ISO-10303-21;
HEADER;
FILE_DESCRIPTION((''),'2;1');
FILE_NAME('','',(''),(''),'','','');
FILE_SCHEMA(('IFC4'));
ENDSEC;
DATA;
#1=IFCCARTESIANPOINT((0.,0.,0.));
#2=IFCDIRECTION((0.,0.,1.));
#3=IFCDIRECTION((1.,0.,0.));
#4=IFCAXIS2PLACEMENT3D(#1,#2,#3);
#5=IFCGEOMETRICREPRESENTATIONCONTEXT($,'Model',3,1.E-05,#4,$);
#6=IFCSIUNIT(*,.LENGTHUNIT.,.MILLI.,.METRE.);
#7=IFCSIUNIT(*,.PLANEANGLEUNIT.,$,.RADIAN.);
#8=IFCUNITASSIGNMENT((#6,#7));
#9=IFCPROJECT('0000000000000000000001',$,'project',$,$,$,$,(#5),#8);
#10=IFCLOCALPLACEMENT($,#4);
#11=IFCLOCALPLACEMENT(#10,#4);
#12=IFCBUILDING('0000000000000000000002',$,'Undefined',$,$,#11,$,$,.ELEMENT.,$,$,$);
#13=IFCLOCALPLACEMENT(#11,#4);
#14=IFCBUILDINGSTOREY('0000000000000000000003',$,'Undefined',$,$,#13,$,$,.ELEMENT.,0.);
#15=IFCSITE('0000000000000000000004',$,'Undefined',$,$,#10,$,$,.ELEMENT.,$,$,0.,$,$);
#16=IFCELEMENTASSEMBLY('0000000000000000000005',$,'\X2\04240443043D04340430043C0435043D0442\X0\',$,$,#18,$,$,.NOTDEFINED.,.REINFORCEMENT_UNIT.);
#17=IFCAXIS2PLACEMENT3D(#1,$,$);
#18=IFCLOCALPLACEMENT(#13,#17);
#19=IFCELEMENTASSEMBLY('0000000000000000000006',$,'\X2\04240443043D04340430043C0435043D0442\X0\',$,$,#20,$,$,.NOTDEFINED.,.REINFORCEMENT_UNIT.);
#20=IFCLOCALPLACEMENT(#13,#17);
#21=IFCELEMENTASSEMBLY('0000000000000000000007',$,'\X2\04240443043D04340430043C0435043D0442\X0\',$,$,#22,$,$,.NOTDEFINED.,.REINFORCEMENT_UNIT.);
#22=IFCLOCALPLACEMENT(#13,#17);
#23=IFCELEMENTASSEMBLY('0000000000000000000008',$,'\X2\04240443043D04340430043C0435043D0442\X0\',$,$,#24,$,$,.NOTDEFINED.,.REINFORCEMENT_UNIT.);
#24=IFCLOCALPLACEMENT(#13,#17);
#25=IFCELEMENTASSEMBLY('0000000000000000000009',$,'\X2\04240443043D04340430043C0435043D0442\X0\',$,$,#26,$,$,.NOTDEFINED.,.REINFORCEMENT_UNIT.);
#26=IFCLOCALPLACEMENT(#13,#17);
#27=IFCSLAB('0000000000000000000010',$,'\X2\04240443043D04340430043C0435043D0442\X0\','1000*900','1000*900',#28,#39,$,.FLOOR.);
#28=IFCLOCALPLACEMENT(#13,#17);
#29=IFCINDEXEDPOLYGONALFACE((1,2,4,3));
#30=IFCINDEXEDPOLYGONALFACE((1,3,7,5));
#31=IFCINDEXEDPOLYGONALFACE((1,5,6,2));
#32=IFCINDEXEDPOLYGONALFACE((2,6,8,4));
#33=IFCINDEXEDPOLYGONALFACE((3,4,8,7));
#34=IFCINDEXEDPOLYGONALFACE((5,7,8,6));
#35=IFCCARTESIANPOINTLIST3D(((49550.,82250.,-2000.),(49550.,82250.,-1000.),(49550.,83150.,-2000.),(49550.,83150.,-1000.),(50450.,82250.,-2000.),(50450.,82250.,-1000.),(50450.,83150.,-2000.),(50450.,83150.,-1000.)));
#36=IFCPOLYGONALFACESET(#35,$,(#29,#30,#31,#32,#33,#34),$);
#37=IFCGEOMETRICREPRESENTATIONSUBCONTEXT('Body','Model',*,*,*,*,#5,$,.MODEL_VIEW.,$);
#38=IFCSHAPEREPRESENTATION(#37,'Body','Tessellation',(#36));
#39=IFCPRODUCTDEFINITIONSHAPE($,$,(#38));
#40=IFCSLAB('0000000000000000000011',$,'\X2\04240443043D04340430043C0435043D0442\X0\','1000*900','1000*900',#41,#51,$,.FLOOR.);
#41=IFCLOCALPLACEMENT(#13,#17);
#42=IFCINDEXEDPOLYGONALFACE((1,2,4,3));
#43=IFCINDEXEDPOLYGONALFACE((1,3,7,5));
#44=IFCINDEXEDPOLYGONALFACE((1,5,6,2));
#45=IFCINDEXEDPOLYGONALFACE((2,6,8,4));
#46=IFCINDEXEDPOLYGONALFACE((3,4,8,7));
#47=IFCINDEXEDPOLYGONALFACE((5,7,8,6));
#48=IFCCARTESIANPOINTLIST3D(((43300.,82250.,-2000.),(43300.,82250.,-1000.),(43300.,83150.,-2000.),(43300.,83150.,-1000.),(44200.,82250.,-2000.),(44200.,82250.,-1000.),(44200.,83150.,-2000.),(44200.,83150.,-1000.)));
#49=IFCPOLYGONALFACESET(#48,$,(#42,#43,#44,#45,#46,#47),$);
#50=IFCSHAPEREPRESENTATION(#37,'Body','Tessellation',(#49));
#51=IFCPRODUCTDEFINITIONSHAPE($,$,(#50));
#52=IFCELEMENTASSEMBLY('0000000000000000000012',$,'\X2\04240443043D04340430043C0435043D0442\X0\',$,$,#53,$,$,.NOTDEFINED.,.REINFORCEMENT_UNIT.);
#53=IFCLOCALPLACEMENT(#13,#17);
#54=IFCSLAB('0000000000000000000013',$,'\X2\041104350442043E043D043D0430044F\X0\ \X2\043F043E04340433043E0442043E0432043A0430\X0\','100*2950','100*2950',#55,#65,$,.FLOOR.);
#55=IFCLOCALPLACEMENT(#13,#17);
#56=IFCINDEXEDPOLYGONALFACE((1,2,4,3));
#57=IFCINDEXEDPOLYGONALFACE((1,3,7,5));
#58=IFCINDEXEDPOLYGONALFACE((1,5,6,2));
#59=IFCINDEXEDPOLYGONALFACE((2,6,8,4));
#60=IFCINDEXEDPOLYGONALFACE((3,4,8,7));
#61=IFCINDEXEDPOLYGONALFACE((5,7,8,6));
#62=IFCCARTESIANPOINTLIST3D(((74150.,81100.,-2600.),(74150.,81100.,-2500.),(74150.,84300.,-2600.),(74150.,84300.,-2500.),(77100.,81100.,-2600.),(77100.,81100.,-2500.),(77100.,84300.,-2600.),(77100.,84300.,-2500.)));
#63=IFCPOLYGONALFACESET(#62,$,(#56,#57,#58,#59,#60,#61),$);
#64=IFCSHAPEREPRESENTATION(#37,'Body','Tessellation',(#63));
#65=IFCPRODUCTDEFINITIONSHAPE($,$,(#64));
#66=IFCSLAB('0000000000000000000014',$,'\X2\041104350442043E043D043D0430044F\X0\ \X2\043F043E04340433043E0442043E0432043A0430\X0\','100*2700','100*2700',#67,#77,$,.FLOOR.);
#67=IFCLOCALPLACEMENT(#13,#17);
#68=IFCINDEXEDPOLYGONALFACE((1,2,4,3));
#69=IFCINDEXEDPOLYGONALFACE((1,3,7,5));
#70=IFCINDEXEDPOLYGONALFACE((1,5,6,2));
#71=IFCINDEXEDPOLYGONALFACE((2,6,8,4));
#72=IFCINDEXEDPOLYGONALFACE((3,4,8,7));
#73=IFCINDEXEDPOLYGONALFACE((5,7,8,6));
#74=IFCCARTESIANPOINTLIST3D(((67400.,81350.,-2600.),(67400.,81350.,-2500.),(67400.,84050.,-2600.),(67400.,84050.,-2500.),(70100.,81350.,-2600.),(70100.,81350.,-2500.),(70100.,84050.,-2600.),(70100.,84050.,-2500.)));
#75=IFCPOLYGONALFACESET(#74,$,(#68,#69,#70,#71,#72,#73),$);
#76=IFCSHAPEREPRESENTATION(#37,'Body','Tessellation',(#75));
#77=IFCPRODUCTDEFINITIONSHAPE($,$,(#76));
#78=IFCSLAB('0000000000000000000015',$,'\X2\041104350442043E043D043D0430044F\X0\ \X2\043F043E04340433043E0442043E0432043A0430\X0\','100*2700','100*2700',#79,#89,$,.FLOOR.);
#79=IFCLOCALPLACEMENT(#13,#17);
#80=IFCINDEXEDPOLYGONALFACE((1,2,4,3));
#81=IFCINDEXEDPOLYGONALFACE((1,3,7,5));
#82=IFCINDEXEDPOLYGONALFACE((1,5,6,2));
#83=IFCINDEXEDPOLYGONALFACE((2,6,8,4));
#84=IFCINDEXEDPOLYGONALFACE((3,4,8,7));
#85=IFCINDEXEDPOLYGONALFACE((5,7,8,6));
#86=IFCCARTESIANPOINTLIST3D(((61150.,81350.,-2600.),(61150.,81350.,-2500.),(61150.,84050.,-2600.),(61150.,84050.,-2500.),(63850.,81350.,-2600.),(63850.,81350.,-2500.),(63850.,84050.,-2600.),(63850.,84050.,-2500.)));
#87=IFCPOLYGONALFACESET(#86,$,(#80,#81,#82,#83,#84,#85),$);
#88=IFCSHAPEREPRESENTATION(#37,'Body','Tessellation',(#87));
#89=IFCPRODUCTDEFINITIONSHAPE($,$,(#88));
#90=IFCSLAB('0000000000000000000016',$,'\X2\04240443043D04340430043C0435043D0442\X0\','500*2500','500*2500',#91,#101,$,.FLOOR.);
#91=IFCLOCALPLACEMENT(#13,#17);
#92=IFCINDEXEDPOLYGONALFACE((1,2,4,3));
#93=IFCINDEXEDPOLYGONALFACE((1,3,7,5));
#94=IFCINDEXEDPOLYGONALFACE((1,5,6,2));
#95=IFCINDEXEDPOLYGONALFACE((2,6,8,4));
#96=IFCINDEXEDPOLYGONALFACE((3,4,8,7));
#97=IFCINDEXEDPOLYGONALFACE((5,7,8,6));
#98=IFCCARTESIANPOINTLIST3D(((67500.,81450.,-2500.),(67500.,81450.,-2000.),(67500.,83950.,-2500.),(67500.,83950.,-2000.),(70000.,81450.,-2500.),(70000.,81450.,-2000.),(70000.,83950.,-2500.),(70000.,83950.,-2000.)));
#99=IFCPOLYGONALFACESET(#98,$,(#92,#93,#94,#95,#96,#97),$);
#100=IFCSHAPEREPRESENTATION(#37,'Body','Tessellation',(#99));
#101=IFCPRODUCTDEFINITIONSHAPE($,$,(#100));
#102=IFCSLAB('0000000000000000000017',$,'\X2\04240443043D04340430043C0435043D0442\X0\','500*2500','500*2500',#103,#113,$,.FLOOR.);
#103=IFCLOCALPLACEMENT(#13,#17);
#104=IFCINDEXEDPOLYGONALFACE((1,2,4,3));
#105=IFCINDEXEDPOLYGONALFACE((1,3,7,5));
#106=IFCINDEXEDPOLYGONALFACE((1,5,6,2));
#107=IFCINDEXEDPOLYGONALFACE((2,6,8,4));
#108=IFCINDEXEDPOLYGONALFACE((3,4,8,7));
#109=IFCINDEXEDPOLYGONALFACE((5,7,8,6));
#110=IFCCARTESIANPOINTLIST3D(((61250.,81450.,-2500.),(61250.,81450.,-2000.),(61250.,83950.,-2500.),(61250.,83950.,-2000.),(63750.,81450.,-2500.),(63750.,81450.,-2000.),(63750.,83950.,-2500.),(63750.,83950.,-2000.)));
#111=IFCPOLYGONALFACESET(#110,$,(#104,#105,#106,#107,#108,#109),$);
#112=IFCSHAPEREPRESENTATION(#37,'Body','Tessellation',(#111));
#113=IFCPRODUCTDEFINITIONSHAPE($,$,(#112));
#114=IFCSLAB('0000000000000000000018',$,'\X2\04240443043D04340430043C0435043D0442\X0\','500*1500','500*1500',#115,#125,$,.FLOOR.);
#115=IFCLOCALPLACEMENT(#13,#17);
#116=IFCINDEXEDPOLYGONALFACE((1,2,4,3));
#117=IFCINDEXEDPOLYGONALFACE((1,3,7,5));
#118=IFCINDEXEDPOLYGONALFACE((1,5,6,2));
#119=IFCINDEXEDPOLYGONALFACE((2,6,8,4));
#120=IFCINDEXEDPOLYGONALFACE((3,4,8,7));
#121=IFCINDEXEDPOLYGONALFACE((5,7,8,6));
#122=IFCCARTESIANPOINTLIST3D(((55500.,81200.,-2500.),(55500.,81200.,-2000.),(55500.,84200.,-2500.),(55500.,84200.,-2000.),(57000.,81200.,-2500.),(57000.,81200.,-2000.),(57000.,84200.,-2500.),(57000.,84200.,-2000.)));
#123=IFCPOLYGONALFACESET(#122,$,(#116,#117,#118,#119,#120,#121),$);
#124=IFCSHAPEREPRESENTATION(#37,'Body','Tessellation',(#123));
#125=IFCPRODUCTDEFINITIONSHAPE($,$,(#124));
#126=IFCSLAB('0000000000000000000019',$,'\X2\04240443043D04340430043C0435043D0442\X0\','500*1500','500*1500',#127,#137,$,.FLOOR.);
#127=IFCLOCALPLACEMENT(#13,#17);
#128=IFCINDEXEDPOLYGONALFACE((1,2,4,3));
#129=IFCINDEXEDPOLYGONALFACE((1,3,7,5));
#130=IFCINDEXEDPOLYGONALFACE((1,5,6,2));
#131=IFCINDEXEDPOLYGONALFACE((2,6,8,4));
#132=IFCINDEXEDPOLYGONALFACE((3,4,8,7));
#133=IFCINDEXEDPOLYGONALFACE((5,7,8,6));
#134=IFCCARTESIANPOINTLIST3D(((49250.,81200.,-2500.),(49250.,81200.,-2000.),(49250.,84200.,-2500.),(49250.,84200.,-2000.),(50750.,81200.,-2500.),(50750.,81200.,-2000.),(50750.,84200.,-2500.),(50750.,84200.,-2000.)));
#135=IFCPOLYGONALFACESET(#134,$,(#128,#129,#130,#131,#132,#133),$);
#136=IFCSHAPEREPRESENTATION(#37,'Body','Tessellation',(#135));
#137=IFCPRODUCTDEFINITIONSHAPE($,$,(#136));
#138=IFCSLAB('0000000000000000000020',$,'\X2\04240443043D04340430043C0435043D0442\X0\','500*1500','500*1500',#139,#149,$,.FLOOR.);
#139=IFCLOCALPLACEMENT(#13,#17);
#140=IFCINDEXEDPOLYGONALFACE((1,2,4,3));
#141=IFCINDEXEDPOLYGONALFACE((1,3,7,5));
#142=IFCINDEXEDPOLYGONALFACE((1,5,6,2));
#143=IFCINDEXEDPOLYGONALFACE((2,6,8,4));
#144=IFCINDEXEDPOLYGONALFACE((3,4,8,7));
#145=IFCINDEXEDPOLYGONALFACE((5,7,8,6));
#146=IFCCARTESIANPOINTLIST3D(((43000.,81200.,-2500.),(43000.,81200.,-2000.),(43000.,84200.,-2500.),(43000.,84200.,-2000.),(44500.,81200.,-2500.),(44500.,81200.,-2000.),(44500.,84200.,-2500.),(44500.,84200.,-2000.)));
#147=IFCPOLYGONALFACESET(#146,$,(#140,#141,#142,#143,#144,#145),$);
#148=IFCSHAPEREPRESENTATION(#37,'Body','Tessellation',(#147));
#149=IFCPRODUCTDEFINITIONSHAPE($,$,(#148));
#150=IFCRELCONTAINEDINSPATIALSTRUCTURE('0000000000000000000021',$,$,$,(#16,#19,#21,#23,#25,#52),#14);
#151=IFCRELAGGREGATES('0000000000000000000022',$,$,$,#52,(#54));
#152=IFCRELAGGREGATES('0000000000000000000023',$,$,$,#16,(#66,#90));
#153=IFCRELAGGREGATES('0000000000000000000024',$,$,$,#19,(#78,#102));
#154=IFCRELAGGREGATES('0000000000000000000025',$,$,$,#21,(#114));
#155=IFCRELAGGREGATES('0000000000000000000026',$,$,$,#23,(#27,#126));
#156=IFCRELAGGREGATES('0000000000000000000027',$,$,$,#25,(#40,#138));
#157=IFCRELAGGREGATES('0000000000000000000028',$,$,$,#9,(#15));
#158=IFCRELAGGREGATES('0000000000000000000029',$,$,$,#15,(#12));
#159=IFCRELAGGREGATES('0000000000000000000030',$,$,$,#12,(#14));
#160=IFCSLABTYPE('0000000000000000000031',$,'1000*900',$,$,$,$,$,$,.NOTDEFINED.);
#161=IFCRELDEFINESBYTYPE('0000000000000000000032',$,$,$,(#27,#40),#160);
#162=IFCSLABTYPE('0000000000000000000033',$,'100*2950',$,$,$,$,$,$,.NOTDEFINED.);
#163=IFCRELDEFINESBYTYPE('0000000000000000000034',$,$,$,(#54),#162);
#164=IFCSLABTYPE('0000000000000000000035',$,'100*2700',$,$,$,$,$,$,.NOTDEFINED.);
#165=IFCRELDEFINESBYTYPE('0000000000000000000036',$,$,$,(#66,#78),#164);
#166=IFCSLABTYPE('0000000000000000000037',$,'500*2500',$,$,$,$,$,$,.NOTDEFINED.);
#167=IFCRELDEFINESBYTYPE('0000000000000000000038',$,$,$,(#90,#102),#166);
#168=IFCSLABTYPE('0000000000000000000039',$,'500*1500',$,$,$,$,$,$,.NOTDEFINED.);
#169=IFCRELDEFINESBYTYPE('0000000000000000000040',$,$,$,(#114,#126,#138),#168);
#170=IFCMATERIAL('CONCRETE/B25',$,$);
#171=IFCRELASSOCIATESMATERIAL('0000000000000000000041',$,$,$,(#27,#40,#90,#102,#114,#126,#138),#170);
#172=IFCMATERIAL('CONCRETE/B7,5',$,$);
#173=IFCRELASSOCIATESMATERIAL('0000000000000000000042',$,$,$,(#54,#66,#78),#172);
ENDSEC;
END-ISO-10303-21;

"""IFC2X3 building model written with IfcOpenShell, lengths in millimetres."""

from ifc_helpers import new_model, si_unit, frame, origin_with_axes, place, context, subcontext, project, spatial, polyline, outline, extrude, material, type_object, element, aggregate, save


model = new_model("IFC2X3")

# Units and contexts
model_context = context("Model", 3, precision=1e-05, world=origin_with_axes())
body_context = subcontext(model_context, "Body", "Model", "MODEL_VIEW")
ifc_project = project(units=[si_unit("LENGTHUNIT", "METRE", prefix="MILLI"), si_unit("PLANEANGLEUNIT", "RADIAN")], contexts=[model_context])

# Site, building, storey
site_placement = place(None, origin_with_axes())
site = spatial("IfcSite", under=ifc_project, at=site_placement, Name="Undefined", CompositionType="ELEMENT", RefElevation=0.0)
building_placement = place(site_placement, origin_with_axes())
building = spatial("IfcBuilding", under=site, at=building_placement, Name="Undefined", CompositionType="ELEMENT")
storey_placement = place(building_placement, origin_with_axes())
storey = spatial("IfcBuildingStorey", under=building, at=storey_placement, Name="Undefined", CompositionType="ELEMENT", Elevation=0.0)

# Element assemblies
assembly_1_placement = place(storey_placement, origin_with_axes())
assembly_1 = element("IfcElementAssembly", 1, at=assembly_1_placement, inside=storey, Name="Фундамент", AssemblyPlace="NOTDEFINED", PredefinedType="REINFORCEMENT_UNIT")
ifc_material_1 = material(Name="CONCRETE/B25")
assembly_2_placement = place(storey_placement, origin_with_axes())
assembly_2 = element("IfcElementAssembly", 2, at=assembly_2_placement, inside=storey, Name="Фундамент", AssemblyPlace="NOTDEFINED", PredefinedType="REINFORCEMENT_UNIT")
assembly_3_placement = place(storey_placement, origin_with_axes())
assembly_3 = element("IfcElementAssembly", 3, at=assembly_3_placement, inside=storey, Name="Фундамент", AssemblyPlace="NOTDEFINED", PredefinedType="REINFORCEMENT_UNIT")
assembly_4_placement = place(storey_placement, origin_with_axes())
assembly_4 = element("IfcElementAssembly", 4, at=assembly_4_placement, inside=storey, Name="Фундамент", AssemblyPlace="NOTDEFINED", PredefinedType="REINFORCEMENT_UNIT")
assembly_5_placement = place(storey_placement, origin_with_axes())
assembly_5 = element("IfcElementAssembly", 5, at=assembly_5_placement, inside=storey, Name="Фундамент", AssemblyPlace="NOTDEFINED", PredefinedType="REINFORCEMENT_UNIT")

# Slabs
ifc_material_2 = material(Name="CONCRETE/B7,5")
slab_type_1 = type_object("IfcSlabType", Name="1000*900", PredefinedType="NOTDEFINED")
slab_1_placement = place(assembly_4_placement, frame((49550.0, 83150.0, -1500.0), z_axis=(0.0, 0.0, 1.0), x_axis=(0.0, -1.0, 0.0)))
slab_1 = element("IfcSlab", 6, at=slab_1_placement, type_object=slab_type_1, material=ifc_material_1, Name="Фундамент", Description="1000*900", ObjectType="1000*900", PredefinedType="FLOOR", context=body_context, shape_type="SweptSolid", body=[
    extrude(outline(polyline([(0.0, 0.0), (900.0, 0.0), (900.0, 900.0), (0.0, 900.0), (0.0, 0.0)])), frame((0.0, 0.0, -500.0), z_axis=(0.0, 0.0, 1.0), x_axis=(1.0, 0.0, 0.0)), (0.0, 0.0, 1.0), 1000.0),
])
slab_2_placement = place(assembly_5_placement, frame((43300.0, 83150.0, -1500.0), z_axis=(0.0, 0.0, 1.0), x_axis=(0.0, -1.0, 0.0)))
slab_2 = element("IfcSlab", 7, at=slab_2_placement, type_object=slab_type_1, material=ifc_material_1, Name="Фундамент", Description="1000*900", ObjectType="1000*900", PredefinedType="FLOOR", context=body_context, shape_type="SweptSolid", body=[
    extrude(outline(polyline([(0.0, 0.0), (900.0, 0.0), (900.0, 900.0), (0.0, 900.0), (0.0, 0.0)])), frame((0.0, 0.0, -500.0), z_axis=(0.0, 0.0, 1.0), x_axis=(1.0, 0.0, 0.0)), (0.0, 0.0, 1.0), 1000.0),
])

# Element assembly, slab
assembly_6_placement = place(storey_placement, origin_with_axes())
assembly_6 = element("IfcElementAssembly", 8, at=assembly_6_placement, inside=storey, Name="Фундамент", AssemblyPlace="NOTDEFINED", PredefinedType="REINFORCEMENT_UNIT")
slab_type_2 = type_object("IfcSlabType", Name="100*2950", PredefinedType="NOTDEFINED")
slab_3_placement = place(assembly_6_placement, frame((74150.0, 84300.0, -2550.0), z_axis=(0.0, 0.0, 1.0), x_axis=(0.0, -1.0, 0.0)))
slab_3 = element("IfcSlab", 9, at=slab_3_placement, type_object=slab_type_2, material=ifc_material_2, Name="Бетонная подготовка", Description="100*2950", ObjectType="100*2950", PredefinedType="FLOOR", context=body_context, shape_type="SweptSolid", body=[
    extrude(outline(polyline([(0.0, 0.0), (3200.0, 0.0), (3200.0, 2950.0), (0.0, 2950.0), (0.0, 0.0)])), frame((0.0, 0.0, -50.0), z_axis=(0.0, 0.0, 1.0), x_axis=(1.0, 0.0, 0.0)), (0.0, 0.0, 1.0), 100.0),
])
aggregate(assembly_6, [slab_3])

# Slabs
slab_type_3 = type_object("IfcSlabType", Name="100*2700", PredefinedType="NOTDEFINED")
slab_4_placement = place(assembly_1_placement, frame((67400.0, 84050.0, -2550.0), z_axis=(0.0, 0.0, 1.0), x_axis=(0.0, -1.0, 0.0)))
slab_4 = element("IfcSlab", 10, at=slab_4_placement, type_object=slab_type_3, material=ifc_material_2, Name="Бетонная подготовка", Description="100*2700", ObjectType="100*2700", PredefinedType="FLOOR", context=body_context, shape_type="SweptSolid", body=[
    extrude(outline(polyline([(0.0, 0.0), (2700.0, 0.0), (2700.0, 2700.0), (0.0, 2700.0), (0.0, 0.0)])), frame((0.0, 0.0, -50.0), z_axis=(0.0, 0.0, 1.0), x_axis=(1.0, 0.0, 0.0)), (0.0, 0.0, 1.0), 100.0),
])
slab_5_placement = place(assembly_2_placement, frame((61150.0, 84050.0, -2550.0), z_axis=(0.0, 0.0, 1.0), x_axis=(0.0, -1.0, 0.0)))
slab_5 = element("IfcSlab", 11, at=slab_5_placement, type_object=slab_type_3, material=ifc_material_2, Name="Бетонная подготовка", Description="100*2700", ObjectType="100*2700", PredefinedType="FLOOR", context=body_context, shape_type="SweptSolid", body=[
    extrude(outline(polyline([(0.0, 0.0), (2700.0, 0.0), (2700.0, 2700.0), (0.0, 2700.0), (0.0, 0.0)])), frame((0.0, 0.0, -50.0), z_axis=(0.0, 0.0, 1.0), x_axis=(1.0, 0.0, 0.0)), (0.0, 0.0, 1.0), 100.0),
])
slab_type_4 = type_object("IfcSlabType", Name="500*2500", PredefinedType="NOTDEFINED")
slab_6_placement = place(assembly_1_placement, frame((67500.0, 83950.0, -2250.0), z_axis=(0.0, 0.0, 1.0), x_axis=(0.0, -1.0, 0.0)))
slab_6 = element("IfcSlab", 12, at=slab_6_placement, type_object=slab_type_4, material=ifc_material_1, Name="Фундамент", Description="500*2500", ObjectType="500*2500", PredefinedType="FLOOR", context=body_context, shape_type="SweptSolid", body=[
    extrude(outline(polyline([(0.0, 0.0), (2500.0, 0.0), (2500.0, 2500.0), (0.0, 2500.0), (0.0, 0.0)])), frame((0.0, 0.0, -250.0), z_axis=(0.0, 0.0, 1.0), x_axis=(1.0, 0.0, 0.0)), (0.0, 0.0, 1.0), 500.0),
])
aggregate(assembly_1, [slab_4, slab_6])
slab_7_placement = place(assembly_2_placement, frame((61250.0, 83950.0, -2250.0), z_axis=(0.0, 0.0, 1.0), x_axis=(0.0, -1.0, 0.0)))
slab_7 = element("IfcSlab", 13, at=slab_7_placement, type_object=slab_type_4, material=ifc_material_1, Name="Фундамент", Description="500*2500", ObjectType="500*2500", PredefinedType="FLOOR", context=body_context, shape_type="SweptSolid", body=[
    extrude(outline(polyline([(0.0, 0.0), (2500.0, 0.0), (2500.0, 2500.0), (0.0, 2500.0), (0.0, 0.0)])), frame((0.0, 0.0, -250.0), z_axis=(0.0, 0.0, 1.0), x_axis=(1.0, 0.0, 0.0)), (0.0, 0.0, 1.0), 500.0),
])
aggregate(assembly_2, [slab_5, slab_7])
slab_type_5 = type_object("IfcSlabType", Name="500*1500", PredefinedType="NOTDEFINED")
slab_8_placement = place(assembly_3_placement, frame((55500.0, 84200.0, -2250.0), z_axis=(0.0, 0.0, 1.0), x_axis=(0.0, -1.0, 0.0)))
slab_8 = element("IfcSlab", 14, at=slab_8_placement, type_object=slab_type_5, material=ifc_material_1, Name="Фундамент", Description="500*1500", ObjectType="500*1500", PredefinedType="FLOOR", context=body_context, shape_type="SweptSolid", body=[
    extrude(outline(polyline([(0.0, 0.0), (3000.0, 0.0), (3000.0, 1500.0), (0.0, 1500.0), (0.0, 0.0)])), frame((0.0, 0.0, -250.0), z_axis=(0.0, 0.0, 1.0), x_axis=(1.0, 0.0, 0.0)), (0.0, 0.0, 1.0), 500.0),
])
aggregate(assembly_3, [slab_8])
slab_9_placement = place(assembly_4_placement, frame((49250.0, 84200.0, -2250.0), z_axis=(0.0, 0.0, 1.0), x_axis=(0.0, -1.0, 0.0)))
slab_9 = element("IfcSlab", 15, at=slab_9_placement, type_object=slab_type_5, material=ifc_material_1, Name="Фундамент", Description="500*1500", ObjectType="500*1500", PredefinedType="FLOOR", context=body_context, shape_type="SweptSolid", body=[
    extrude(outline(polyline([(0.0, 0.0), (3000.0, 0.0), (3000.0, 1500.0), (0.0, 1500.0), (0.0, 0.0)])), frame((0.0, 0.0, -250.0), z_axis=(0.0, 0.0, 1.0), x_axis=(1.0, 0.0, 0.0)), (0.0, 0.0, 1.0), 500.0),
])
aggregate(assembly_4, [slab_1, slab_9])
slab_10_placement = place(assembly_5_placement, frame((43000.0, 84200.0, -2250.0), z_axis=(0.0, 0.0, 1.0), x_axis=(0.0, -1.0, 0.0)))
slab_10 = element("IfcSlab", 16, at=slab_10_placement, type_object=slab_type_5, material=ifc_material_1, Name="Фундамент", Description="500*1500", ObjectType="500*1500", PredefinedType="FLOOR", context=body_context, shape_type="SweptSolid", body=[
    extrude(outline(polyline([(0.0, 0.0), (3000.0, 0.0), (3000.0, 1500.0), (0.0, 1500.0), (0.0, 0.0)])), frame((0.0, 0.0, -250.0), z_axis=(0.0, 0.0, 1.0), x_axis=(1.0, 0.0, 0.0)), (0.0, 0.0, 1.0), 500.0),
])
aggregate(assembly_5, [slab_2, slab_10])

save(model, "model.ifc")
